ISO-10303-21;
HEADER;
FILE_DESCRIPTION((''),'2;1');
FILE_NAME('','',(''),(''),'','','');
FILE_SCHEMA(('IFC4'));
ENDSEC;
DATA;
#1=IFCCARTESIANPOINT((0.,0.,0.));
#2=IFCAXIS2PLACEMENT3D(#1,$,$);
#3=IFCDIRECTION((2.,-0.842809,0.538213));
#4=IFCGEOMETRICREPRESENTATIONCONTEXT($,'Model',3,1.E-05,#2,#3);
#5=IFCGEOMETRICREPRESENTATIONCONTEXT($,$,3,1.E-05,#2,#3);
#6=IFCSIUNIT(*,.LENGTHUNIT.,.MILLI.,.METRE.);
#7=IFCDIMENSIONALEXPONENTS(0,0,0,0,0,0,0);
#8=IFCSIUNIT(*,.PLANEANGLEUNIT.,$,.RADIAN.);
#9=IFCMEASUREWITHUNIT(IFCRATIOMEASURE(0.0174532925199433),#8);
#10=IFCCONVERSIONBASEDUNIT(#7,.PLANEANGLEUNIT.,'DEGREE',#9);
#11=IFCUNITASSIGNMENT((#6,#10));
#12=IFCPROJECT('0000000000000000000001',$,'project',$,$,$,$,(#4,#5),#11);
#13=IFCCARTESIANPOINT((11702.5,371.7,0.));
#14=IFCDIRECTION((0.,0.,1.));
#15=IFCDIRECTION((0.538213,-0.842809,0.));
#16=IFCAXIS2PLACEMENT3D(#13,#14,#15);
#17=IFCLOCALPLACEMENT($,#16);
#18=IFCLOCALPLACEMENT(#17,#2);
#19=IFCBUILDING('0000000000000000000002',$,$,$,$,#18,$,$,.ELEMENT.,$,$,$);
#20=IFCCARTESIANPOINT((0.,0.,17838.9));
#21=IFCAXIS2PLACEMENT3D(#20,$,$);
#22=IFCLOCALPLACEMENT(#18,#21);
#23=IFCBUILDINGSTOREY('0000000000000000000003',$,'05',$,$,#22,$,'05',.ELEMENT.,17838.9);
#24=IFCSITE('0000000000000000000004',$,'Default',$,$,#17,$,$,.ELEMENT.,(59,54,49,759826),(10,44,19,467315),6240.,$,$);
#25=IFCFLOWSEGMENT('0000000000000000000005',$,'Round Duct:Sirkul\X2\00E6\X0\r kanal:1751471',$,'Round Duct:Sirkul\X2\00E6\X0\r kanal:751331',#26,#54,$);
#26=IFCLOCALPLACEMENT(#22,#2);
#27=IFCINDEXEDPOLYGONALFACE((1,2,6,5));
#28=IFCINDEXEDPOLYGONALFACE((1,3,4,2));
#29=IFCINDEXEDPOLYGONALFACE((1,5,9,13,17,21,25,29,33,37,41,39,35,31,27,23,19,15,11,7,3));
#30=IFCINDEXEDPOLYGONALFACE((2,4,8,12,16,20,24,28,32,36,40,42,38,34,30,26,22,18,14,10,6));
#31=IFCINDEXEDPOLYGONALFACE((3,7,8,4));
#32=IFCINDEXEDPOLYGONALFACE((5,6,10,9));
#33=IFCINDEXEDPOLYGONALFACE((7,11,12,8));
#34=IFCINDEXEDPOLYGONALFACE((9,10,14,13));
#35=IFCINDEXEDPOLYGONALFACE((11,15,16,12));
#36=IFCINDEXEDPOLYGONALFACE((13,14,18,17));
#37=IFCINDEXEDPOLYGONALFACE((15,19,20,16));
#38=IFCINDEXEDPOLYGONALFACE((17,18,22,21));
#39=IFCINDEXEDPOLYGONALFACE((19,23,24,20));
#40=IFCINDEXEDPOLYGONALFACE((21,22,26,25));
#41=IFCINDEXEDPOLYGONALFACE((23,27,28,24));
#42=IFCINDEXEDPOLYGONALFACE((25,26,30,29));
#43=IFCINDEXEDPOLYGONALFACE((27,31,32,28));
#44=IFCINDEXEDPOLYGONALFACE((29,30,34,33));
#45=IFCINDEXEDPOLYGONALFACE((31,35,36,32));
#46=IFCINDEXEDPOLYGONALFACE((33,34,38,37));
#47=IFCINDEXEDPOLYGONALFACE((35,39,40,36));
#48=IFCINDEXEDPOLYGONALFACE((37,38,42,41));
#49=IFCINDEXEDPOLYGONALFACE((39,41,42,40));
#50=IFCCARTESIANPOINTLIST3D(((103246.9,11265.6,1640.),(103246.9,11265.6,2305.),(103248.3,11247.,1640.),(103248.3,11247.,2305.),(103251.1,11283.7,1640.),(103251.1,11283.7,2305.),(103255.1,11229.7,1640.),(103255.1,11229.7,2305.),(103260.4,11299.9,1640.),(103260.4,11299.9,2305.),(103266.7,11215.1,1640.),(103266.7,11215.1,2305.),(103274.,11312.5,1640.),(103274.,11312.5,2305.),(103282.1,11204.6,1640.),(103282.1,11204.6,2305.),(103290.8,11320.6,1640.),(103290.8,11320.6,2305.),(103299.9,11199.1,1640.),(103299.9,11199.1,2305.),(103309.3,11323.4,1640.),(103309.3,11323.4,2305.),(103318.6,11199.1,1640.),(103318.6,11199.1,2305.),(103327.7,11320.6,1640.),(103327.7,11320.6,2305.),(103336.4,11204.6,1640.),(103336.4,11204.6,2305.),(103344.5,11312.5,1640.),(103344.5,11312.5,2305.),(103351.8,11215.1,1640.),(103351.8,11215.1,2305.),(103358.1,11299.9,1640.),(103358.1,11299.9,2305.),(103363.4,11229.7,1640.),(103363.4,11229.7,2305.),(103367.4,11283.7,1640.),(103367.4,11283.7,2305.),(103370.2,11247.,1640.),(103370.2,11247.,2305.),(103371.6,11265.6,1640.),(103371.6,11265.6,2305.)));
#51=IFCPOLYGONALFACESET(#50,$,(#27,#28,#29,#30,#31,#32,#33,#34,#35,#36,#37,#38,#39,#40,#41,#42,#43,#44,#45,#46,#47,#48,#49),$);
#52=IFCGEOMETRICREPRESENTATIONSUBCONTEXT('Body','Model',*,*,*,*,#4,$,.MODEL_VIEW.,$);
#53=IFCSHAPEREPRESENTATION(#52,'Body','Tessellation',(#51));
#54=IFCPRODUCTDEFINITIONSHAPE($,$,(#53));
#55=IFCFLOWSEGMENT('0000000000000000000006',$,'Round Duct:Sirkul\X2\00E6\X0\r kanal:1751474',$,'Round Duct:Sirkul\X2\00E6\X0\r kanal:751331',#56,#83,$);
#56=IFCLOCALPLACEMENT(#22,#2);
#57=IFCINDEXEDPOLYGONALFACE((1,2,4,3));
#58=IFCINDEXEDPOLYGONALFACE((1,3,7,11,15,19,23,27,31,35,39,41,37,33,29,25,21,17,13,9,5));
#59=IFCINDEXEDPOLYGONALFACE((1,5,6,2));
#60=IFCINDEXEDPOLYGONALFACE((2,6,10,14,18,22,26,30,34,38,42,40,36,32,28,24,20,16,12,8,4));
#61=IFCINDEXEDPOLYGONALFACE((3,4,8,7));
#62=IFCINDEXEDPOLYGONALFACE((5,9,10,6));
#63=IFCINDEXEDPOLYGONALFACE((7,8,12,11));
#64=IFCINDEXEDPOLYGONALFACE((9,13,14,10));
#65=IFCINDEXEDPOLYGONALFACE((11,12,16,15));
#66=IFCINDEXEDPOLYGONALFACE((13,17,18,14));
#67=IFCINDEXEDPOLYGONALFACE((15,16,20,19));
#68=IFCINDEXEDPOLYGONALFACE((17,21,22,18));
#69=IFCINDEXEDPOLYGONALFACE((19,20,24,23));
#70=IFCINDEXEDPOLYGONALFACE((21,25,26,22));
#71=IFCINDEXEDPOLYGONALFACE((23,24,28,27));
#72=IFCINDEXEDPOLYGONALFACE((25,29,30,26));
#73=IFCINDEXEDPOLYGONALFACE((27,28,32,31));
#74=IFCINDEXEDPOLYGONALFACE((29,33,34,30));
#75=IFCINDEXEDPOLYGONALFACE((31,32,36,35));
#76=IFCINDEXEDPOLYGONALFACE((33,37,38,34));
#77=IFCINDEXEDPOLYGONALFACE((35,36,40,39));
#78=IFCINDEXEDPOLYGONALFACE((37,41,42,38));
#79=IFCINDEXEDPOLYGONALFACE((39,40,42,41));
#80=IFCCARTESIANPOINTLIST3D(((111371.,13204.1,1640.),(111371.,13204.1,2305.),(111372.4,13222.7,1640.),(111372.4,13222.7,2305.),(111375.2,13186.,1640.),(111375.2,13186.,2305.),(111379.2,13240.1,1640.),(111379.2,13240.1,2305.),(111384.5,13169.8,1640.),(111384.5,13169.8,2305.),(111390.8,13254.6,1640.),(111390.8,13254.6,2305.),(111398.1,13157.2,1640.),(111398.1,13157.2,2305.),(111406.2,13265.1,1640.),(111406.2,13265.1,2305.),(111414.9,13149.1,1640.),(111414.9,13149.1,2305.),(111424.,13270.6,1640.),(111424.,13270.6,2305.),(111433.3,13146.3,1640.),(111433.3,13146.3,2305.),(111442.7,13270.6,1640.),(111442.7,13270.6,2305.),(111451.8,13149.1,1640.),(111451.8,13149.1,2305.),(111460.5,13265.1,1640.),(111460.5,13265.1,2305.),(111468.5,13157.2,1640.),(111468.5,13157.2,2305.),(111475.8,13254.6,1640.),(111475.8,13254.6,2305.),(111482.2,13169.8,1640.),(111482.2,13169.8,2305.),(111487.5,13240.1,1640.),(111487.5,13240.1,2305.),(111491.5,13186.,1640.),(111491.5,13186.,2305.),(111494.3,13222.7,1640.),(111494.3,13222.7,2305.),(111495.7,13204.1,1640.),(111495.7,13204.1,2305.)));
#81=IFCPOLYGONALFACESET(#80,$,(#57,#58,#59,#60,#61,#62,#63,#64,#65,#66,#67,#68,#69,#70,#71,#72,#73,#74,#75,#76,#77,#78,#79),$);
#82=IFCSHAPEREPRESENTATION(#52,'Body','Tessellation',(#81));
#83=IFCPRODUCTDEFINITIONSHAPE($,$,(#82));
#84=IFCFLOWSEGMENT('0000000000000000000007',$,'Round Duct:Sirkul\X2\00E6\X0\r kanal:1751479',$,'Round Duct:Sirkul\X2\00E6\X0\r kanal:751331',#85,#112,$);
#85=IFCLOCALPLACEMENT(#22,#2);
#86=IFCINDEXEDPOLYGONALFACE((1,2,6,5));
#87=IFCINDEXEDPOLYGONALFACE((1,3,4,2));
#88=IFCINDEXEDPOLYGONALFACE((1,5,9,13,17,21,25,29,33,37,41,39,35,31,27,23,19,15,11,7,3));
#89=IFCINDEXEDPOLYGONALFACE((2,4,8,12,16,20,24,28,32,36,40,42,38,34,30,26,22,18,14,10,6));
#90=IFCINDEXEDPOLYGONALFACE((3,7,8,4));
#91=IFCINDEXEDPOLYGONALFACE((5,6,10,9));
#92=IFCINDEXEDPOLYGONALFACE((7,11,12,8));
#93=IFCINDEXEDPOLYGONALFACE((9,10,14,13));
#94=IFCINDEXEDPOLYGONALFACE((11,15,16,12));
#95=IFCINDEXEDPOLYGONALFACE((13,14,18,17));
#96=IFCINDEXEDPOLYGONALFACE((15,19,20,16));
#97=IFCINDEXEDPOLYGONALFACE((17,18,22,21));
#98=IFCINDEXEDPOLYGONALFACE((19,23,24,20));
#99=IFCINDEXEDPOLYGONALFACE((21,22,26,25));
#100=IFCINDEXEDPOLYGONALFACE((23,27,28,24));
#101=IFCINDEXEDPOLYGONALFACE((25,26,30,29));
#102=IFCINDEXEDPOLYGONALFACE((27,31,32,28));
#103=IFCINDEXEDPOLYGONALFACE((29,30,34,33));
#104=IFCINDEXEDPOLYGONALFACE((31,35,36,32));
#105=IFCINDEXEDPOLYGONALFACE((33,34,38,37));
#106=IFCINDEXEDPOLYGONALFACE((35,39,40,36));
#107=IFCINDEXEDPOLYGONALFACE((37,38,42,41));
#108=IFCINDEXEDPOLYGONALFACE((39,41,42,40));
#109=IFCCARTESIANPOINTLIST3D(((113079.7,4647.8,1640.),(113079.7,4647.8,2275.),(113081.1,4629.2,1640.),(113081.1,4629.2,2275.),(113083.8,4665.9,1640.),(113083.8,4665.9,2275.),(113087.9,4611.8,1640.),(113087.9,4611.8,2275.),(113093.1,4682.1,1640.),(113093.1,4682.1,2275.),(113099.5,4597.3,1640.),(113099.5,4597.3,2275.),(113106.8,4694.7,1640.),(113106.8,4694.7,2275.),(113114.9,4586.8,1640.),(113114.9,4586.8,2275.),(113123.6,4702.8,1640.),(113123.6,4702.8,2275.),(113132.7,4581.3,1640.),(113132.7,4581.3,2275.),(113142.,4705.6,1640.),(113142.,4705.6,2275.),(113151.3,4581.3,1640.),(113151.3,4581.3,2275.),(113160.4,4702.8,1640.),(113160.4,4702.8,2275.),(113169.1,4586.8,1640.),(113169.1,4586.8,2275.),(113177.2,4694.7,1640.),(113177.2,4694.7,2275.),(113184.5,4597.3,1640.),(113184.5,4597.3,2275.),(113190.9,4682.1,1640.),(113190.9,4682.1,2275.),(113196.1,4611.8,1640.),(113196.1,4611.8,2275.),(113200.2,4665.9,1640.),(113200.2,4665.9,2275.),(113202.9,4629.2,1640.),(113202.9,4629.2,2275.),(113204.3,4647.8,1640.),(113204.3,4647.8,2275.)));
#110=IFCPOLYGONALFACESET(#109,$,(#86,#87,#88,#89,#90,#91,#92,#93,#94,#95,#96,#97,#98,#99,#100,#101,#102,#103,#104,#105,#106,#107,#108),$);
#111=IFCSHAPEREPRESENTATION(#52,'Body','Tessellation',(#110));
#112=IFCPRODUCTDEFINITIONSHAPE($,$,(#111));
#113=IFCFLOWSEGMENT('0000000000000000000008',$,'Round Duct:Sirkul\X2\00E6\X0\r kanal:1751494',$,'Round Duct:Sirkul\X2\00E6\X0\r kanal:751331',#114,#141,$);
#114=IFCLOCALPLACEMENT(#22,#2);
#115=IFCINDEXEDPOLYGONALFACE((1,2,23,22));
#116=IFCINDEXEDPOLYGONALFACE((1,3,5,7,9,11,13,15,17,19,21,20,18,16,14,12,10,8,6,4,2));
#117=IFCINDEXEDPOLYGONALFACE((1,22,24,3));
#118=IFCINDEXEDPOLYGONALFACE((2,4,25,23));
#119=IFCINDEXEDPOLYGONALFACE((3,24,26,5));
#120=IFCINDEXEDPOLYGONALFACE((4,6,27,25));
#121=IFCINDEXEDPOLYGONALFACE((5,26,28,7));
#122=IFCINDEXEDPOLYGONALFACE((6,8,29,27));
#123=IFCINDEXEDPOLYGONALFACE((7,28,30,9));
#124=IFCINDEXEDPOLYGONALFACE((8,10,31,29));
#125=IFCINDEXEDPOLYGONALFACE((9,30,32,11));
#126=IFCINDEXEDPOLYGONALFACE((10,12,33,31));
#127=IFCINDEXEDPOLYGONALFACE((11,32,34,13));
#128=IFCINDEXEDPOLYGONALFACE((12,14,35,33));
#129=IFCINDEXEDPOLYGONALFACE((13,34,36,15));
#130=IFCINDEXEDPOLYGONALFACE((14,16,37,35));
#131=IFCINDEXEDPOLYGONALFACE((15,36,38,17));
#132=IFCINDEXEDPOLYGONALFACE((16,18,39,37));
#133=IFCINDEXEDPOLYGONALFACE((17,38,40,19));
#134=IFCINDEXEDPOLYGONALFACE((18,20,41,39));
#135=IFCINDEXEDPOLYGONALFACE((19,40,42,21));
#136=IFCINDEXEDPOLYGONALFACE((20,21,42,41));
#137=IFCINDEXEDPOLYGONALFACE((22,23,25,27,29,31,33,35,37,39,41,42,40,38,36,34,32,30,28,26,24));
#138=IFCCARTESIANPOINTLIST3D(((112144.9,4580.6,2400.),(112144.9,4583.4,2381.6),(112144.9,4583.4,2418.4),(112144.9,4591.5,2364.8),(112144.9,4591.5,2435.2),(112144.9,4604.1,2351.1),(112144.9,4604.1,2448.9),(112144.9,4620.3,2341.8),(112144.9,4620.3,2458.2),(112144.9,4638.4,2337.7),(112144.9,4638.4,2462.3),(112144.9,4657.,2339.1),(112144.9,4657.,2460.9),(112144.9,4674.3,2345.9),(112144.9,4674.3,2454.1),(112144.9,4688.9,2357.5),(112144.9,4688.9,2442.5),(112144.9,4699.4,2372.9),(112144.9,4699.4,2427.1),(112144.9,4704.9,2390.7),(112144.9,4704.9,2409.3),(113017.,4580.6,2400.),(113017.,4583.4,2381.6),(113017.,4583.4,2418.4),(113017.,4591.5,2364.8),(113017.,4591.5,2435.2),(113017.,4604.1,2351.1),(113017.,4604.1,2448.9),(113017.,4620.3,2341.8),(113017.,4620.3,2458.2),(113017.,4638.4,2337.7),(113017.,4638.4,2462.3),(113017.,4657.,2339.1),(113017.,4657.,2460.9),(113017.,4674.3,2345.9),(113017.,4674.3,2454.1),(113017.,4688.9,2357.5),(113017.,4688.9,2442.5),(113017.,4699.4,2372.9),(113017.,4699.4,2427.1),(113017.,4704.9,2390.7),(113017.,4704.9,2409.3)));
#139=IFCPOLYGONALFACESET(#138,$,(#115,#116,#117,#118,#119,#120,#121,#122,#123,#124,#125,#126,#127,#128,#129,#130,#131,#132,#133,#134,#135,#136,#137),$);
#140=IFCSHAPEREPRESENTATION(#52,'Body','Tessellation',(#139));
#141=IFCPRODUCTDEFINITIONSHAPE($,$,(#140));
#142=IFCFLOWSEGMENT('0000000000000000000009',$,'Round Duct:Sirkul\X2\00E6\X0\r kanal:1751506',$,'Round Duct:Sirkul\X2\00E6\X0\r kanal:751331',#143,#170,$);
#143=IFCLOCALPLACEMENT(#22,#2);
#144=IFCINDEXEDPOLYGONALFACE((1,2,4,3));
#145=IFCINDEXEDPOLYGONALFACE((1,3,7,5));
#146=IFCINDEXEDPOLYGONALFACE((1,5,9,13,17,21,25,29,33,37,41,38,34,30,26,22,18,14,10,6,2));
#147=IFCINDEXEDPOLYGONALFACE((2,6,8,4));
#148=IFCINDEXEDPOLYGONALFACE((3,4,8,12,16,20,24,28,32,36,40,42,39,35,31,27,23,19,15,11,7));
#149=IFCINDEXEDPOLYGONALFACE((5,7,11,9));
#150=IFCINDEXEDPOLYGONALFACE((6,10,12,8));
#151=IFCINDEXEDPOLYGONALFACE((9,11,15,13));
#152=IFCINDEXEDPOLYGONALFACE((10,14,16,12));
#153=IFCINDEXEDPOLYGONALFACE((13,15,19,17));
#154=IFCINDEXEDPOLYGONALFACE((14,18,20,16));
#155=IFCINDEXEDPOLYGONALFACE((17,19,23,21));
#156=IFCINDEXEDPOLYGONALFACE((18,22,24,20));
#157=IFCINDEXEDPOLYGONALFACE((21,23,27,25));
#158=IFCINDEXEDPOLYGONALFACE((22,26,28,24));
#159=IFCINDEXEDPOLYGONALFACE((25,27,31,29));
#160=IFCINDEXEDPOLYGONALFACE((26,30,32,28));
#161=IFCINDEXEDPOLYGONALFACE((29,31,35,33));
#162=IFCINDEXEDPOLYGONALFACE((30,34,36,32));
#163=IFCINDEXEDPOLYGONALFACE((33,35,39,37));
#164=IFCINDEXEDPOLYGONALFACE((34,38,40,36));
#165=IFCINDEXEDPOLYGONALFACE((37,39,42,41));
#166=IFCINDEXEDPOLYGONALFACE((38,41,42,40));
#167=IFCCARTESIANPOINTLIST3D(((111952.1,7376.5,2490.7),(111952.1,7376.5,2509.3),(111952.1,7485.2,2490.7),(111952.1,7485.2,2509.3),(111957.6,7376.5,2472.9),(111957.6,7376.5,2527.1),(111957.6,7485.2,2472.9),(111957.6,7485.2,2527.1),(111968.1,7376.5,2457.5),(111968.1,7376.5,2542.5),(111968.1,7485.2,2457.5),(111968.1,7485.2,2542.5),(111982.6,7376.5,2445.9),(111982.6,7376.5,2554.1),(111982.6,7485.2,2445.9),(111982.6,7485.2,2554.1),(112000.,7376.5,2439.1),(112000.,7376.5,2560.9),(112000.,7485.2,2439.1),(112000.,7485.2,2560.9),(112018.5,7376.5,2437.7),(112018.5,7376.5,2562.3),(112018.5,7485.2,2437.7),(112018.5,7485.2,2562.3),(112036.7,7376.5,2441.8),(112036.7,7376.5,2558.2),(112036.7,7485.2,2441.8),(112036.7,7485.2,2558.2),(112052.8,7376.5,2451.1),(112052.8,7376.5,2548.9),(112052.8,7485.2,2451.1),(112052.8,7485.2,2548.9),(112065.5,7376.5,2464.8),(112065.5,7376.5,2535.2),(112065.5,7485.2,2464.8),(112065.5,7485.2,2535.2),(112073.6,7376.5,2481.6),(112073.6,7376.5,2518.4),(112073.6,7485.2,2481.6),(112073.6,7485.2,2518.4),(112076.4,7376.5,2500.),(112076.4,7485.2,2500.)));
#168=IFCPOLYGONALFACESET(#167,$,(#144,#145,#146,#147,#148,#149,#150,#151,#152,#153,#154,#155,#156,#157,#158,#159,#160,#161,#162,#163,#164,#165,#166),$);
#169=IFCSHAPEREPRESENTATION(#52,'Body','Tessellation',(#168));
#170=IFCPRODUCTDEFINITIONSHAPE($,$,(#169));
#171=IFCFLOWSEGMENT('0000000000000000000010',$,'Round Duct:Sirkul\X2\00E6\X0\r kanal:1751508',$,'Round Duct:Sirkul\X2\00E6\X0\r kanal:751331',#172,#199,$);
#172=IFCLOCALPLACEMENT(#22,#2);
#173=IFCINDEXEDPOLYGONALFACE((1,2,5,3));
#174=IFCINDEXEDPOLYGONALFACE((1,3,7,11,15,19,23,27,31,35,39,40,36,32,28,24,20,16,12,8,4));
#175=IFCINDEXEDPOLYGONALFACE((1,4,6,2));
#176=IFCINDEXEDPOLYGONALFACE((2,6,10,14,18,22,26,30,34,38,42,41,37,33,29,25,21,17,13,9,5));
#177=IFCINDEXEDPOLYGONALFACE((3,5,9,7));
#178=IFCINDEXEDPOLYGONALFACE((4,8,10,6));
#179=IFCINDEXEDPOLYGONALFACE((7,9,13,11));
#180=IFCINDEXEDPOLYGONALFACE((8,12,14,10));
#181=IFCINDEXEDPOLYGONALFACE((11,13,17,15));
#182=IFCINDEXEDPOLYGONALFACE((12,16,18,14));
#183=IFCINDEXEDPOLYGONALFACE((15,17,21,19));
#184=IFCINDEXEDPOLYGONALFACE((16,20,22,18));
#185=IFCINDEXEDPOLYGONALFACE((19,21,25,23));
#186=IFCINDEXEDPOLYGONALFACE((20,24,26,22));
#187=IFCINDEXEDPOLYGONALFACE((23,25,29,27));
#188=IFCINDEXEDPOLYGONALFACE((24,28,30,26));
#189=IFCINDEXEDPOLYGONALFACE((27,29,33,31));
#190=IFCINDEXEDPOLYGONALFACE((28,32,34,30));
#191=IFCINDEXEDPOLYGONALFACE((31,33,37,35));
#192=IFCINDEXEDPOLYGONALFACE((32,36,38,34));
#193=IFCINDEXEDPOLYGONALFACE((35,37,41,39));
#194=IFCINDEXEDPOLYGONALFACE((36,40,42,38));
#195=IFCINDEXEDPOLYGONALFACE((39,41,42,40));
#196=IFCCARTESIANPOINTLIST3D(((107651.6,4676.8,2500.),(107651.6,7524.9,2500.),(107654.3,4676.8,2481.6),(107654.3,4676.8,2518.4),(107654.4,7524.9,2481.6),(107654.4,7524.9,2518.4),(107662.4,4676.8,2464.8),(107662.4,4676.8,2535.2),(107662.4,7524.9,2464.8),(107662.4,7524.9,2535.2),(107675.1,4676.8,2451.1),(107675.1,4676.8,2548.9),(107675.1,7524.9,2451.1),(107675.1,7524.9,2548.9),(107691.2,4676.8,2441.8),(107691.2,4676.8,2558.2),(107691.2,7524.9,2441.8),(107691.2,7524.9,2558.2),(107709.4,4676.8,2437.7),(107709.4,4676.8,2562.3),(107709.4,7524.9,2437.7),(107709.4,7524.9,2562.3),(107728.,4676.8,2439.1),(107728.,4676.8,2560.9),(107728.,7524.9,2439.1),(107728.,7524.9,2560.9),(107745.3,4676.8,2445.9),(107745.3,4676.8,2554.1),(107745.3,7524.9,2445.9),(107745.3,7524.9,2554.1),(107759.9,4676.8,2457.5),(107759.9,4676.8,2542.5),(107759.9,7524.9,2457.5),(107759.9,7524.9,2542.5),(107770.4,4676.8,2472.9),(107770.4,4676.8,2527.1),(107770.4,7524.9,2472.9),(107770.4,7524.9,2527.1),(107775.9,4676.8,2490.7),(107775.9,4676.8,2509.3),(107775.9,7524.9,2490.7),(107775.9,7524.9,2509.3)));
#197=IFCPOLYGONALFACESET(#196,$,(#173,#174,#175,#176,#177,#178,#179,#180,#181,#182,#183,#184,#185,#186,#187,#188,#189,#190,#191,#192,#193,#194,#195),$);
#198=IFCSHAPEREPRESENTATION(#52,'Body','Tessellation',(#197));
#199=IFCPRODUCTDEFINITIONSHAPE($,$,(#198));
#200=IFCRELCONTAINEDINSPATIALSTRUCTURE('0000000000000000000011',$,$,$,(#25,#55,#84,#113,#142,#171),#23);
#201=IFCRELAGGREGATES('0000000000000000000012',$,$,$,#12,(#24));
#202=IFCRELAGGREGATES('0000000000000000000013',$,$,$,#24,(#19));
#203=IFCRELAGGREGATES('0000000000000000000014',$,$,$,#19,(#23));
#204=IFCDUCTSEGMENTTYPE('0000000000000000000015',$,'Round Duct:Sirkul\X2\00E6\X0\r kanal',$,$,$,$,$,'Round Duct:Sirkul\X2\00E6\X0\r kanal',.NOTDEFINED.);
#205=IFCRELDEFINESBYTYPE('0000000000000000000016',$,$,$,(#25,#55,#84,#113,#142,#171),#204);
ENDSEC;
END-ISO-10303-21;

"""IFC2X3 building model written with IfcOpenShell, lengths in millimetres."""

from ifc_helpers import new_model, entity, si_unit, converted_unit, direction, frame, frame_2d, origin, origin_2d_with_axis, place, context, subcontext, project, spatial, circle, extrude, type_object, element, save


model = new_model("IFC2X3")

# Units and contexts
model_context = context("Model", 3, precision=1e-05, world=origin(), true_north=direction((2.0, -0.842809, 0.538213)))
context_of_model = context(None, 3, precision=1e-05, world=origin(), true_north=direction((2.0, -0.842809, 0.538213)))
body_context = subcontext(model_context, "Body", "Model", "MODEL_VIEW")
ifc_project = project(units=[si_unit("LENGTHUNIT", "METRE", prefix="MILLI"), converted_unit("PLANEANGLEUNIT", "DEGREE", entity("IfcRatioMeasure", 0.0174532925199433), si_unit("PLANEANGLEUNIT", "RADIAN"), dimensions=[0, 0, 0, 0, 0, 0, 0])], contexts=[model_context, context_of_model])

# Site, building, storey
site_placement = place(None, frame((11702.5, 371.7, 0.0), z_axis=(0.0, 0.0, 1.0), x_axis=(0.538213, -0.842809, 0.0)))
site = spatial("IfcSite", under=ifc_project, at=site_placement, Name="Default", CompositionType="ELEMENT", RefLatitude=(59, 54, 49, 759826), RefLongitude=(10, 44, 19, 467315), RefElevation=6240.0)
building_placement = place(site_placement, origin())
building = spatial("IfcBuilding", under=site, at=building_placement, CompositionType="ELEMENT")
storey_placement = place(building_placement, frame((0.0, 0.0, 17838.9)))
storey = spatial("IfcBuildingStorey", under=building, at=storey_placement, Name="05", LongName="05", CompositionType="ELEMENT", Elevation=17838.9)

# Flow segments
duct_segment_type = type_object("IfcDuctSegmentType", Name="Round Duct:Sirkulær kanal", ElementType="Round Duct:Sirkulær kanal", PredefinedType="NOTDEFINED")
flow_segment_1_placement = place(storey_placement, origin())
element("IfcFlowSegment", 1, at=flow_segment_1_placement, inside=storey, type_object=duct_segment_type, Name="Round Duct:Sirkulær kanal:1751471", ObjectType="Round Duct:Sirkulær kanal:751331", context=body_context, shape_type="SweptSolid", body=[
    extrude(circle(Radius=62.5, at=origin_2d_with_axis()), frame((103309.3, 11260.9, 1640.0), z_axis=(0.0, 0.0, 1.0), x_axis=(0.0, 1.0, 0.0)), (0.0, 0.0, 1.0), 665.0),
])
flow_segment_2_placement = place(storey_placement, origin())
element("IfcFlowSegment", 2, at=flow_segment_2_placement, inside=storey, type_object=duct_segment_type, Name="Round Duct:Sirkulær kanal:1751474", ObjectType="Round Duct:Sirkulær kanal:751331", context=body_context, shape_type="SweptSolid", body=[
    extrude(circle(Radius=62.5, at=origin_2d_with_axis()), frame((111433.3, 13208.8, 1640.0), z_axis=(0.0, 0.0, 1.0), x_axis=(0.0, -1.0, 0.0)), (0.0, 0.0, 1.0), 665.0),
])
flow_segment_3_placement = place(storey_placement, origin())
element("IfcFlowSegment", 3, at=flow_segment_3_placement, inside=storey, type_object=duct_segment_type, Name="Round Duct:Sirkulær kanal:1751479", ObjectType="Round Duct:Sirkulær kanal:751331", context=body_context, shape_type="SweptSolid", body=[
    extrude(circle(Radius=62.5, at=frame_2d((0.0, 0.0), x_axis=(1.0, 0.0))), frame((113142.0, 4643.1, 1640.0), z_axis=(0.0, 0.0, 1.0), x_axis=(0.0, 1.0, 0.0)), (0.0, 0.0, 1.0), 635.0),
])
flow_segment_4_placement = place(storey_placement, origin())
element("IfcFlowSegment", 4, at=flow_segment_4_placement, inside=storey, type_object=duct_segment_type, Name="Round Duct:Sirkulær kanal:1751494", ObjectType="Round Duct:Sirkulær kanal:751331", context=body_context, shape_type="SweptSolid", body=[
    extrude(circle(Radius=62.5, at=frame_2d((0.0, 0.0), x_axis=(1.0, 0.0))), frame((112144.9, 4643.1, 2400.0), z_axis=(1.0, 0.0, 0.0), x_axis=(0.0, -1.0, 0.0)), (0.0, 0.0, 1.0), 872.1),
])
flow_segment_5_placement = place(storey_placement, origin())
element("IfcFlowSegment", 5, at=flow_segment_5_placement, inside=storey, type_object=duct_segment_type, Name="Round Duct:Sirkulær kanal:1751506", ObjectType="Round Duct:Sirkulær kanal:751331", context=body_context, shape_type="SweptSolid", body=[
    extrude(circle(Radius=62.5, at=frame_2d((0.0, 0.0), x_axis=(1.0, 0.0))), frame((112013.9, 7376.5, 2500.0), z_axis=(0.000003, 1.0, 0.0), x_axis=(1.0, -0.000003, 0.0)), (0.0, 0.0, 1.0), 108.7),
])
flow_segment_6_placement = place(storey_placement, origin())
element("IfcFlowSegment", 6, at=flow_segment_6_placement, inside=storey, type_object=duct_segment_type, Name="Round Duct:Sirkulær kanal:1751508", ObjectType="Round Duct:Sirkulær kanal:751331", context=body_context, shape_type="SweptSolid", body=[
    extrude(circle(Radius=62.5, at=origin_2d_with_axis()), frame((107714.1, 4676.8, 2500.0), z_axis=(0.000002, 1.0, 0.0), x_axis=(-1.0, 0.000002, 0.0)), (0.0, 0.0, 1.0), 2848.1),
])

save(model, "model.ifc")
